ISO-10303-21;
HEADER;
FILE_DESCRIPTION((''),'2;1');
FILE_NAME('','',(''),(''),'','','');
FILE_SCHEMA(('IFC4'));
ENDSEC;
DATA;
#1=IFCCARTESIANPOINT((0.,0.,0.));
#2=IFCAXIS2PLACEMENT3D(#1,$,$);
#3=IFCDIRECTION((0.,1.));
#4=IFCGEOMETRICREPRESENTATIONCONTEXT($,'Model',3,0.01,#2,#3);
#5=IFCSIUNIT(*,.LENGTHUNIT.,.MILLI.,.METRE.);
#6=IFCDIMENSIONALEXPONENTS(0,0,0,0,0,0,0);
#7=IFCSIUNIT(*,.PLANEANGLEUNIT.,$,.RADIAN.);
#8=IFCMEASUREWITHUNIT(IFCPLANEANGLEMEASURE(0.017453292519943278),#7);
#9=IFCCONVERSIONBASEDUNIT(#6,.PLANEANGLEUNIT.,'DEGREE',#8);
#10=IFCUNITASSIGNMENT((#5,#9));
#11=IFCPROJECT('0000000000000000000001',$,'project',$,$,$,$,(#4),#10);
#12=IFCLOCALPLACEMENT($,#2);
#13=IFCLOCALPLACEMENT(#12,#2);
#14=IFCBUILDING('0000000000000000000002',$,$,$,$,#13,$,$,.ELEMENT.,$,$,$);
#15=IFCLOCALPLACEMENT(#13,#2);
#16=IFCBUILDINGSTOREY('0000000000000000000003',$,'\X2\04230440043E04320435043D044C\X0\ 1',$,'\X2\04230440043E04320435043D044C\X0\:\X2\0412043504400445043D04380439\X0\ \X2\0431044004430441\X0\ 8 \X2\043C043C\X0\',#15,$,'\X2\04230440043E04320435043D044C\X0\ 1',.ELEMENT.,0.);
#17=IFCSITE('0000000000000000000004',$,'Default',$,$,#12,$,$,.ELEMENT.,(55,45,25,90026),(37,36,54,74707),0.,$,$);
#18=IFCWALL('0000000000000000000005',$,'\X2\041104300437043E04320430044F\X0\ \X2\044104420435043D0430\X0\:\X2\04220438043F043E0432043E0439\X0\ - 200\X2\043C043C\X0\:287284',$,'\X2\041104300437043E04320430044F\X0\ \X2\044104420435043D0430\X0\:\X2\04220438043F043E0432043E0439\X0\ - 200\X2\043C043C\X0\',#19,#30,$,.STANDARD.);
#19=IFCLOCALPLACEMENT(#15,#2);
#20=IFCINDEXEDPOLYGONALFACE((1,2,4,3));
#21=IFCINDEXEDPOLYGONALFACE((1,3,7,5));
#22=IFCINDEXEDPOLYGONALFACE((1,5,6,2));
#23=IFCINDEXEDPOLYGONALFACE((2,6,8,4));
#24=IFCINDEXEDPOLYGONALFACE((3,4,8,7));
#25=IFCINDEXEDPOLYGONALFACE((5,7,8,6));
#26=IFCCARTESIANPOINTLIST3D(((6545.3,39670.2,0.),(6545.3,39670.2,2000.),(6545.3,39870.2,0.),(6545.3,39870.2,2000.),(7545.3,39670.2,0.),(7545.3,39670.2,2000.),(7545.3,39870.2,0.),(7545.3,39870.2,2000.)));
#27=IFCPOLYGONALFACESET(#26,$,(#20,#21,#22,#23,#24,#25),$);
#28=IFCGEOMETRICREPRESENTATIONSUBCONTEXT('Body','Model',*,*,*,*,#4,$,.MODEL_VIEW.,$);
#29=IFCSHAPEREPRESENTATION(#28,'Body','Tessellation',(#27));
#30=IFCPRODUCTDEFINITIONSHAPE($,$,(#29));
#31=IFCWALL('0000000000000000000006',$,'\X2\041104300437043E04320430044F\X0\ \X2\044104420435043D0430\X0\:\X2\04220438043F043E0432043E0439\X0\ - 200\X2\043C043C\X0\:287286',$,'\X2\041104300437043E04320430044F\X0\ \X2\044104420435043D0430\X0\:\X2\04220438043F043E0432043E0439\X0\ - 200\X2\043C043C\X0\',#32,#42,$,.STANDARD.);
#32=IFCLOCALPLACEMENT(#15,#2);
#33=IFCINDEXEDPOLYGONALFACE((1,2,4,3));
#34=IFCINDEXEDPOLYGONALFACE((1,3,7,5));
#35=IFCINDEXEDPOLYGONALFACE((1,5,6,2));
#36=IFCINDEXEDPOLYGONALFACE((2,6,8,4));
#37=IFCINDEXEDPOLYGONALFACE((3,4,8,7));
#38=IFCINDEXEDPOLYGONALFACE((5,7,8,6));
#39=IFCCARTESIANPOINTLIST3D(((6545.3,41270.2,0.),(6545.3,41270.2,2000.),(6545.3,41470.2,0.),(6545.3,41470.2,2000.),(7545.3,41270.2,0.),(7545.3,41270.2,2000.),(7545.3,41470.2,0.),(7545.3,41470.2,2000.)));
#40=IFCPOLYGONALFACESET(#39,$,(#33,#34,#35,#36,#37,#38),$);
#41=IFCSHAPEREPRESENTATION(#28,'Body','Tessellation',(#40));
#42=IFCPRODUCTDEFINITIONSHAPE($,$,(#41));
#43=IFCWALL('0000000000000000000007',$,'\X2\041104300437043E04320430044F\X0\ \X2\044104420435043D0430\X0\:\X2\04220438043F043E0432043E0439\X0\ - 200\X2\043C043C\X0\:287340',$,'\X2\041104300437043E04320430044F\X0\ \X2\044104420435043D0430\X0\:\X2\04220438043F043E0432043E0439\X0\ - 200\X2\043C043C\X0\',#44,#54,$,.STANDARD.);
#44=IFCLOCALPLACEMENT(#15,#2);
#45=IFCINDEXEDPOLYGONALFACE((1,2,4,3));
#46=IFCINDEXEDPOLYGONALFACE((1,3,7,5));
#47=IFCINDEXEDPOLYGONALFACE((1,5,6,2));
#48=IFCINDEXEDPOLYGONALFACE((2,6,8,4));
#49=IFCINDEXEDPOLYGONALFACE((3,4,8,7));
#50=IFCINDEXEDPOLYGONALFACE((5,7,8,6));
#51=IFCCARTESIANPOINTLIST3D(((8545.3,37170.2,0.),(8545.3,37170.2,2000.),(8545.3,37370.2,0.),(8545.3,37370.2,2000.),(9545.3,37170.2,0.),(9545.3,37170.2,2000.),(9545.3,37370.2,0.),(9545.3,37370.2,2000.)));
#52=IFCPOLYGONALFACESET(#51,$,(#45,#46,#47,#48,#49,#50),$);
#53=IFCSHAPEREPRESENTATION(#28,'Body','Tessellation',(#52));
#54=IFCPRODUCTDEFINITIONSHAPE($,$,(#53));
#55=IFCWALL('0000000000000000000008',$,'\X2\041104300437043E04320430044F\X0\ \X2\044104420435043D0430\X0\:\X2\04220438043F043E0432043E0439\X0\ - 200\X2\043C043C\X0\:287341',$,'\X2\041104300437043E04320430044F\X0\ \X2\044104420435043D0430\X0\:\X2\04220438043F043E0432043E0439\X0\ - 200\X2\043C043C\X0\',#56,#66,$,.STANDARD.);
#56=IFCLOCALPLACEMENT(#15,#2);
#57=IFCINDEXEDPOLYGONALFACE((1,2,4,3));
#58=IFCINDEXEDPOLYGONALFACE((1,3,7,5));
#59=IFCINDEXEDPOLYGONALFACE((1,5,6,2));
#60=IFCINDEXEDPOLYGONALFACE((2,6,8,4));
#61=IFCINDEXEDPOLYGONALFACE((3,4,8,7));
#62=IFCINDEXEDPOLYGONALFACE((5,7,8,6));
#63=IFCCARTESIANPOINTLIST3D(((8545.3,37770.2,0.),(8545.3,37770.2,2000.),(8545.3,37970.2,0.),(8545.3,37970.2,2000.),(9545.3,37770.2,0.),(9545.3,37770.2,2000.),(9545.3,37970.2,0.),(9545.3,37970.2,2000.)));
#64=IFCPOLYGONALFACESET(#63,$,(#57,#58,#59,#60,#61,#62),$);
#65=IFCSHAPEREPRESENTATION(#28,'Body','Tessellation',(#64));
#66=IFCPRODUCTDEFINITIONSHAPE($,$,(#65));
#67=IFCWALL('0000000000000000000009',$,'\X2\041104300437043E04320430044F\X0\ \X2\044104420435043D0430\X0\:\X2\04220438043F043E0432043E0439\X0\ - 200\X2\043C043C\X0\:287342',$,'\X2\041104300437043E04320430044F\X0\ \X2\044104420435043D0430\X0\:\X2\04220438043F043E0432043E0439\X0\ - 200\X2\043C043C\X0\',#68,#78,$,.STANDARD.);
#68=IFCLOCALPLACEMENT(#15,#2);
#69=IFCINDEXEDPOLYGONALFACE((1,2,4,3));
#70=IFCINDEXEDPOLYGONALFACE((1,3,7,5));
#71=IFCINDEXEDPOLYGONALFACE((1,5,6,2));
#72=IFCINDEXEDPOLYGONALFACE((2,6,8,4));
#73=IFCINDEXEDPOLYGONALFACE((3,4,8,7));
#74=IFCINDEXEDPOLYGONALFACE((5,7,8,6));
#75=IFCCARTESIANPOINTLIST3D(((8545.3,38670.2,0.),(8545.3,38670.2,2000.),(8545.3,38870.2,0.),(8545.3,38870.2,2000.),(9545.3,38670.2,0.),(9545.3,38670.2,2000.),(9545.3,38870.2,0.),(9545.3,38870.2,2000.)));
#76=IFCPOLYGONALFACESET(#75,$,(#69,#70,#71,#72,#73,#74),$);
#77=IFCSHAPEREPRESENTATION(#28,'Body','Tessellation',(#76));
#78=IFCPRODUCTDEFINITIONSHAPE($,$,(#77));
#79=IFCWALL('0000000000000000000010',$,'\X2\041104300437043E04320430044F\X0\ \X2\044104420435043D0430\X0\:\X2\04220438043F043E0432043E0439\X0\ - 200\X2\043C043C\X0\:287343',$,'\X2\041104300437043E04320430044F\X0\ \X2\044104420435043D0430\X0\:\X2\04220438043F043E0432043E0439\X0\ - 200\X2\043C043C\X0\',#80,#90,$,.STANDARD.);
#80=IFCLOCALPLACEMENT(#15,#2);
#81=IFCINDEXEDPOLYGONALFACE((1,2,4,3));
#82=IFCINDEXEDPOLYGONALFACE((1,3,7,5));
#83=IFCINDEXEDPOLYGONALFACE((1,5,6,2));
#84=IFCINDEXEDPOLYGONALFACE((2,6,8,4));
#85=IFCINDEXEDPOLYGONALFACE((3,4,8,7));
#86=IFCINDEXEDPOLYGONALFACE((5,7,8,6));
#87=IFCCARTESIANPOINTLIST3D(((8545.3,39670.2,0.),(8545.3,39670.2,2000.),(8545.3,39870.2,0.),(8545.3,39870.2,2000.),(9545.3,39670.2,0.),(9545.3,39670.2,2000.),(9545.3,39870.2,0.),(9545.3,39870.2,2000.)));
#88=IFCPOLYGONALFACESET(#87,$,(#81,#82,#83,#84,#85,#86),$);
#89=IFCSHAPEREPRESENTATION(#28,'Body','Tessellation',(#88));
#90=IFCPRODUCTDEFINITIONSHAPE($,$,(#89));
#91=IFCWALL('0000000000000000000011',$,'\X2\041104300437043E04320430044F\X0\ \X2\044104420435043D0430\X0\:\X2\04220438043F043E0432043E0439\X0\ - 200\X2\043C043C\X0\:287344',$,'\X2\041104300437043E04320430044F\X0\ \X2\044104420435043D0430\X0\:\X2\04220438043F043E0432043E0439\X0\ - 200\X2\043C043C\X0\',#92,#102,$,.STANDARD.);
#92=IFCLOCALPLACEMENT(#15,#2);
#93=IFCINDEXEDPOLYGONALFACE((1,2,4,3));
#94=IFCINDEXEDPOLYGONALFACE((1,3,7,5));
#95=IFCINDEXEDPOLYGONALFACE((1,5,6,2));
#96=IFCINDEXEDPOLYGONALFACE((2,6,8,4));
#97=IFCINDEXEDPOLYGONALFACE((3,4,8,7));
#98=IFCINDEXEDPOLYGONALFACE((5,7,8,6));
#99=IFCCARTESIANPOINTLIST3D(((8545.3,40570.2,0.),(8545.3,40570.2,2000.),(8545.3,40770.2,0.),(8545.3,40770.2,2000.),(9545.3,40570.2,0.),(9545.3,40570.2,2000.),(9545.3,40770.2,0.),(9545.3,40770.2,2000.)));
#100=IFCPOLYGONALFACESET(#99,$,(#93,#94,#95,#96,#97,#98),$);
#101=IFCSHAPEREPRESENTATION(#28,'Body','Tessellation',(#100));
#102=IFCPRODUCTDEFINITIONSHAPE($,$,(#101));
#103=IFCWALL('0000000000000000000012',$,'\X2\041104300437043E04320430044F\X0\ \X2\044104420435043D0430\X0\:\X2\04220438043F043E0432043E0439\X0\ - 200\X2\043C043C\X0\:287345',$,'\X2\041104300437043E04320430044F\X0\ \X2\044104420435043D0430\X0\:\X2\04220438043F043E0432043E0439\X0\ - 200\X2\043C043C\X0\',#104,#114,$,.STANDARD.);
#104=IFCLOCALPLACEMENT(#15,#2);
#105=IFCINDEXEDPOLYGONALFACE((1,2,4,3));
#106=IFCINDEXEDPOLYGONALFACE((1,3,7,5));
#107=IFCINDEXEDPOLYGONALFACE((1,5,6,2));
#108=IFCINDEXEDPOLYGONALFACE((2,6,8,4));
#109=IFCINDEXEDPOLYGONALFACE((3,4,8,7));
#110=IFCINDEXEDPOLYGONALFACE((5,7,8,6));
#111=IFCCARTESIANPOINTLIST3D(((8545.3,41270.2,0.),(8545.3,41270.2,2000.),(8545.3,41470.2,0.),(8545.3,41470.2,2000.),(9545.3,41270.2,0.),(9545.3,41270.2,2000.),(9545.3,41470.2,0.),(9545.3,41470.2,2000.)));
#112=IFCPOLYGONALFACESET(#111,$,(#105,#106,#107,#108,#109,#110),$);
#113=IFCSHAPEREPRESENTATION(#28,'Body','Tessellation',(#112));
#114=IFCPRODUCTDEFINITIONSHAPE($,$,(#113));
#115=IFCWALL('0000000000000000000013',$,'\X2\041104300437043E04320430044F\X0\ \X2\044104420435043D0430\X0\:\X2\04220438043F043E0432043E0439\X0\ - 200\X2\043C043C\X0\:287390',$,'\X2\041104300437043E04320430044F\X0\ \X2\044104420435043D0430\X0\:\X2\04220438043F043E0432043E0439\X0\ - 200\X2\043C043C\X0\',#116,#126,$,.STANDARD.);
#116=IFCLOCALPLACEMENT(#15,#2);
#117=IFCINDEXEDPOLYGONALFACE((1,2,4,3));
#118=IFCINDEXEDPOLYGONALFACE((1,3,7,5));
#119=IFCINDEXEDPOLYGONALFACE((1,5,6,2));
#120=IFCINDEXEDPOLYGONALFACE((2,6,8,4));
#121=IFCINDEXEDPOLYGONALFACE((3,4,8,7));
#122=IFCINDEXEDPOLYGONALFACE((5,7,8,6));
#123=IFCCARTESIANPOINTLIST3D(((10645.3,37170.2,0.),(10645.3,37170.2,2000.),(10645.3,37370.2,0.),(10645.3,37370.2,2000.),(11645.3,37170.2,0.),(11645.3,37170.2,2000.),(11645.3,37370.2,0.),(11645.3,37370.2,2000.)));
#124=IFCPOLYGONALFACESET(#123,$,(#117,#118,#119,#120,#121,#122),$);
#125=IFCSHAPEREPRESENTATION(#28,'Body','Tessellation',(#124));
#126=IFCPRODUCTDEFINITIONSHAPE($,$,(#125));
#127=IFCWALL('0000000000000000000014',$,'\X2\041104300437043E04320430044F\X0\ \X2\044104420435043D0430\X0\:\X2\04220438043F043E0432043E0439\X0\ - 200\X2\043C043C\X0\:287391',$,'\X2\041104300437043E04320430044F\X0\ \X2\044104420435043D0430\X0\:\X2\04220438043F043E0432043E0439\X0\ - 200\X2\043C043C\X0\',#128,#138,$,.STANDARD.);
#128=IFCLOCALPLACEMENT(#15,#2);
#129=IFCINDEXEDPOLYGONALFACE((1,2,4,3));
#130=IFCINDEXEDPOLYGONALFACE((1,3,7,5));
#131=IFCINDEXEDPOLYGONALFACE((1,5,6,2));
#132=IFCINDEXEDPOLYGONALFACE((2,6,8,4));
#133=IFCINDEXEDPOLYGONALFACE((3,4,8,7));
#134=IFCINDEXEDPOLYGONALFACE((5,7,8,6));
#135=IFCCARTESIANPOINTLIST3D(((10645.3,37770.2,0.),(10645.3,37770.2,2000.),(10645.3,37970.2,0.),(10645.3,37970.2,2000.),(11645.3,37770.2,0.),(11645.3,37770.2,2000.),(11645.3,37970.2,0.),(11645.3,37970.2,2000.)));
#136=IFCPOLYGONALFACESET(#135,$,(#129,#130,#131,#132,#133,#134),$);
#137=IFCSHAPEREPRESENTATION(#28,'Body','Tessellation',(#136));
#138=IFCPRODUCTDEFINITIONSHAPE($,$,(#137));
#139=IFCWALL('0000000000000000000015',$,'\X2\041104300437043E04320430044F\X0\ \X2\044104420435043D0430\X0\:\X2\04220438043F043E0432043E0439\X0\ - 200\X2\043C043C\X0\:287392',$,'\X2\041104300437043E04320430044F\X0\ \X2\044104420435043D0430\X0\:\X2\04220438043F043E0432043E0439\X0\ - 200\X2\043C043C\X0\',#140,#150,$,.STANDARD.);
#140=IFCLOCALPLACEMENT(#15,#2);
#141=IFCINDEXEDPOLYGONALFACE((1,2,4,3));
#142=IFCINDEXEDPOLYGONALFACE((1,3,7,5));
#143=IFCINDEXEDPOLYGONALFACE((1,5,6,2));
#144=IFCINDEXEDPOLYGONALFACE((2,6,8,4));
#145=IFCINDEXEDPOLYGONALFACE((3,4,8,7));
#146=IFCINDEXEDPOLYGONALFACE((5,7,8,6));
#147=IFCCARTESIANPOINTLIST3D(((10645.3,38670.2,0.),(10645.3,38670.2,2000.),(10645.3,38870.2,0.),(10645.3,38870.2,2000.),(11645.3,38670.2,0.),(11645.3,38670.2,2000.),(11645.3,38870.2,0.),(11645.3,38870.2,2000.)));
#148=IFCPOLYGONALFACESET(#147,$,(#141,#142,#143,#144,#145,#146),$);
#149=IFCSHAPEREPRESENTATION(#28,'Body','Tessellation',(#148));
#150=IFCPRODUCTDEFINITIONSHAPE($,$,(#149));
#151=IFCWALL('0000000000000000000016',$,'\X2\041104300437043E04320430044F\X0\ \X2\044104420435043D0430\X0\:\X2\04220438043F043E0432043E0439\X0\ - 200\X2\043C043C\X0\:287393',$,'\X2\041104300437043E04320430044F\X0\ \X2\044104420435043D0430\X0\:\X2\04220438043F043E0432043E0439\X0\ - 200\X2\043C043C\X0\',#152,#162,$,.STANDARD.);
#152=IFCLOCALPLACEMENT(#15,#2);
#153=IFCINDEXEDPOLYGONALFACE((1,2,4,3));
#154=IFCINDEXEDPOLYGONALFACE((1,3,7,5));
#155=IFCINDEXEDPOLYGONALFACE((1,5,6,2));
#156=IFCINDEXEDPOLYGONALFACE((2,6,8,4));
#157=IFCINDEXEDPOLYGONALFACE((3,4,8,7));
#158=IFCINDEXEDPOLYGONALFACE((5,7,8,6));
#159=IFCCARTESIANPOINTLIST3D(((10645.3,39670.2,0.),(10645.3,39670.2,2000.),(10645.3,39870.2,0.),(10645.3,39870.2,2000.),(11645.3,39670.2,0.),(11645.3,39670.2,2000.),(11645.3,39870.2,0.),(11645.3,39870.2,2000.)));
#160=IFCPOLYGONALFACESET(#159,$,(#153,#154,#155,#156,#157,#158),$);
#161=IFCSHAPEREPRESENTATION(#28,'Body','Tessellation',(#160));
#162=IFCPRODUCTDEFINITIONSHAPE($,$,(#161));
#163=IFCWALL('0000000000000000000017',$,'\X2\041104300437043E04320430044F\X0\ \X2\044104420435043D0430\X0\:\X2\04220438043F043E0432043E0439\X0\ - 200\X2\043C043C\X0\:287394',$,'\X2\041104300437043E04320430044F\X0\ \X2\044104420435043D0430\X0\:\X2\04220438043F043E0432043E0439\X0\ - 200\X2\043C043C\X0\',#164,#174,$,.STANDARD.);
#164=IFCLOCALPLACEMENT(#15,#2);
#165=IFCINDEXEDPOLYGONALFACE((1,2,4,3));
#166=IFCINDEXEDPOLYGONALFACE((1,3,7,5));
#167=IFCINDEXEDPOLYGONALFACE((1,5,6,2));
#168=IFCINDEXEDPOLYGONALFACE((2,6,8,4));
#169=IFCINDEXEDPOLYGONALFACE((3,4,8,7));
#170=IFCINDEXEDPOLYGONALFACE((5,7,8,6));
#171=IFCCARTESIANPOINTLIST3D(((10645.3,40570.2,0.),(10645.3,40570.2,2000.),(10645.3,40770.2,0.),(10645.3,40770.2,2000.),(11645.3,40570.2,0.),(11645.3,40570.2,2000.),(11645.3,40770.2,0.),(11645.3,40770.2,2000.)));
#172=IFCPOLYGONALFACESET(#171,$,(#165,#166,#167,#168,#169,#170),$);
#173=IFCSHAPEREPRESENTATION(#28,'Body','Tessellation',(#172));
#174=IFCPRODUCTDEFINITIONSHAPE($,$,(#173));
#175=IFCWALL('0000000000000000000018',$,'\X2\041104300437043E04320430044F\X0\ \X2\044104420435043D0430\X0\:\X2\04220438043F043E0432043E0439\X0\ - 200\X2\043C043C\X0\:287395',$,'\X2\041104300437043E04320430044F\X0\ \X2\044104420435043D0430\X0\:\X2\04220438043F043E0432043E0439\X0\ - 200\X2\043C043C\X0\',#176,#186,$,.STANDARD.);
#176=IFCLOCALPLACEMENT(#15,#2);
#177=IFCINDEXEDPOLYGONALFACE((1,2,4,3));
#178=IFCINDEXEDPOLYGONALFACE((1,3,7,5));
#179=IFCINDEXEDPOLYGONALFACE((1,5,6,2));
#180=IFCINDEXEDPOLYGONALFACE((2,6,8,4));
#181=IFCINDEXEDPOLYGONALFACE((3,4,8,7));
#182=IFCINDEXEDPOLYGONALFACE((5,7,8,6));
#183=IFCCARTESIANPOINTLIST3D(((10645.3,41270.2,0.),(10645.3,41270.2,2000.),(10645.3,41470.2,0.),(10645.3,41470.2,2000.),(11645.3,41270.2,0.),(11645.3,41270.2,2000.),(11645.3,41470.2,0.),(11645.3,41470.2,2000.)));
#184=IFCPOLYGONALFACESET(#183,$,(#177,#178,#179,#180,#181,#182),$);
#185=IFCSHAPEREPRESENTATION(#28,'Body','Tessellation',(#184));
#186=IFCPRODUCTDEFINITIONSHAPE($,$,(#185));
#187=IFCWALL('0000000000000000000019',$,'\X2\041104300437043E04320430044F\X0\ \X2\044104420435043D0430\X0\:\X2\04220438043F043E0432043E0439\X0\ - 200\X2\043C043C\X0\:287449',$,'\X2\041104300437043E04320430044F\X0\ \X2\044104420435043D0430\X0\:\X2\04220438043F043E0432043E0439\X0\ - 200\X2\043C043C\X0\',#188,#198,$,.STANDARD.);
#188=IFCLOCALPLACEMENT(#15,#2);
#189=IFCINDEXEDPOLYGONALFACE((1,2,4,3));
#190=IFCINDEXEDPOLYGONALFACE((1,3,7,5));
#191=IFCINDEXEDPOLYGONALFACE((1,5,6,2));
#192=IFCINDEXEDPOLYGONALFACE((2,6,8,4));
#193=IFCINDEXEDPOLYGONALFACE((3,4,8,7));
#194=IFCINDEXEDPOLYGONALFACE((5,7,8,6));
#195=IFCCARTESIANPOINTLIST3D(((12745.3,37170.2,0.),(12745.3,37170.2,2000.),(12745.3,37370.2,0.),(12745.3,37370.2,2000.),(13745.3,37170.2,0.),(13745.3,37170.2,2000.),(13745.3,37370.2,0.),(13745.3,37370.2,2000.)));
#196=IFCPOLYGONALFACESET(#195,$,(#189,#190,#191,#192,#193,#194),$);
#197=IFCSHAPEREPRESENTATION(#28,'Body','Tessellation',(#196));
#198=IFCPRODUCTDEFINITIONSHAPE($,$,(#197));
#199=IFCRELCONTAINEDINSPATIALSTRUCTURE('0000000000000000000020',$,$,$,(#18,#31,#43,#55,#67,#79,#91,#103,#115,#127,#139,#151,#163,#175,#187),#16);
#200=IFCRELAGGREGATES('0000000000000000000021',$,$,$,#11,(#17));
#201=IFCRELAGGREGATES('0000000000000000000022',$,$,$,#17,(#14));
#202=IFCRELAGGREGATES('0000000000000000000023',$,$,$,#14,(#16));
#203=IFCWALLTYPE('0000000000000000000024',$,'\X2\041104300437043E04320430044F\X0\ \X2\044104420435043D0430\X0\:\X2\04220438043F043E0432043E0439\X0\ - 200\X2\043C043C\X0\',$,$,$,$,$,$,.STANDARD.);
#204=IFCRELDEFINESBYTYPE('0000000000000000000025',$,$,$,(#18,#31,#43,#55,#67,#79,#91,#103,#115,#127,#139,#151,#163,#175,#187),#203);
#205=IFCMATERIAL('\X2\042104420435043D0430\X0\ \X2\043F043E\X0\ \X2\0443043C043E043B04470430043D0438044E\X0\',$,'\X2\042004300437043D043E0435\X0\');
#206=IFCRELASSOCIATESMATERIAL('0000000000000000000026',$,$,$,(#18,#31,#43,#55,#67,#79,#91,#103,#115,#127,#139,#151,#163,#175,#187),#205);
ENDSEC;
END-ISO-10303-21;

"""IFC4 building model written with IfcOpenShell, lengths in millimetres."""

from ifc_helpers import new_model, entity, si_unit, converted_unit, direction, frame, origin, place, context, subcontext, project, spatial, indexed_curve, outline, extrude, material, type_object, element, save


model = new_model("IFC4")

# Units and contexts
model_context = context("Model", 3, precision=0.01, world=origin(), true_north=direction((0.0, 1.0)))
body_context = subcontext(model_context, "Body", "Model", "MODEL_VIEW")
ifc_project = project(units=[si_unit("LENGTHUNIT", "METRE", prefix="MILLI"), converted_unit("PLANEANGLEUNIT", "DEGREE", entity("IfcPlaneAngleMeasure", 0.017453292519943278), si_unit("PLANEANGLEUNIT", "RADIAN"), dimensions=[0, 0, 0, 0, 0, 0, 0])], contexts=[model_context])

# Site, building, storey
site_placement = place(None, origin())
site = spatial("IfcSite", under=ifc_project, at=site_placement, Name="Default", CompositionType="ELEMENT", RefLatitude=(55, 45, 25, 90026), RefLongitude=(37, 36, 54, 74707), RefElevation=0.0)
building_placement = place(site_placement, origin())
building = spatial("IfcBuilding", under=site, at=building_placement, CompositionType="ELEMENT")
storey_placement = place(building_placement, origin())
storey = spatial("IfcBuildingStorey", under=building, at=storey_placement, Name="Уровень 1", ObjectType="Уровень:Верхний брус 8 мм", LongName="Уровень 1", CompositionType="ELEMENT", Elevation=0.0)

# Walls
ifc_material = material(Name="Стена по умолчанию", Category="Разное")
wall_type = type_object("IfcWallType", Name="Базовая стена:Типовой - 200мм", PredefinedType="STANDARD")
wall_1_placement = place(storey_placement, frame((6545.3, 39770.2, 0.0)))
element("IfcWall", 1, at=wall_1_placement, inside=storey, type_object=wall_type, material=ifc_material, Name="Базовая стена:Типовой - 200мм:287284", ObjectType="Базовая стена:Типовой - 200мм", PredefinedType="STANDARD", context=body_context, shape_type="SweptSolid", body=[
    extrude(outline(indexed_curve([(1000.0, 100.0), (0.0, 100.0), (0.0, -100.0), (1000.0, -100.0), (1000.0, 100.0)], self_intersect=False)), origin(), (0.0, 0.0, 1.0), 2000.0),
])
wall_2_placement = place(storey_placement, frame((6545.3, 41370.2, 0.0)))
element("IfcWall", 2, at=wall_2_placement, inside=storey, type_object=wall_type, material=ifc_material, Name="Базовая стена:Типовой - 200мм:287286", ObjectType="Базовая стена:Типовой - 200мм", PredefinedType="STANDARD", context=body_context, shape_type="SweptSolid", body=[
    extrude(outline(indexed_curve([(1000.0, 100.0), (0.0, 100.0), (0.0, -100.0), (1000.0, -100.0), (1000.0, 100.0)], self_intersect=False)), origin(), (0.0, 0.0, 1.0), 2000.0),
])
wall_3_placement = place(storey_placement, frame((8545.3, 37270.2, 0.0)))
element("IfcWall", 3, at=wall_3_placement, inside=storey, type_object=wall_type, material=ifc_material, Name="Базовая стена:Типовой - 200мм:287340", ObjectType="Базовая стена:Типовой - 200мм", PredefinedType="STANDARD", context=body_context, shape_type="SweptSolid", body=[
    extrude(outline(indexed_curve([(1000.0, 100.0), (0.0, 100.0), (0.0, -100.0), (1000.0, -100.0), (1000.0, 100.0)], self_intersect=False)), origin(), (0.0, 0.0, 1.0), 2000.0),
])
for number, where, name in (
    (4, (8545.3, 37870.2, 0.0), "Базовая стена:Типовой - 200мм:287341"),
    (5, (8545.3, 38770.2, 0.0), "Базовая стена:Типовой - 200мм:287342"),
):
    element("IfcWall", number, at=place(storey_placement, frame(where)), inside=storey, type_object=wall_type, material=ifc_material, Name=name, ObjectType="Базовая стена:Типовой - 200мм", PredefinedType="STANDARD", context=body_context, shape_type="SweptSolid", body=[
        extrude(outline(indexed_curve([(1000.0, 100.0), (0.0, 100.0), (0.0, -100.0), (1000.0, -100.0), (1000.0, 100.0)], self_intersect=False)), origin(), (0.0, 0.0, 1.0), 2000.0),
    ])
wall_4_placement = place(storey_placement, frame((8545.3, 39770.2, 0.0)))
element("IfcWall", 6, at=wall_4_placement, inside=storey, type_object=wall_type, material=ifc_material, Name="Базовая стена:Типовой - 200мм:287343", ObjectType="Базовая стена:Типовой - 200мм", PredefinedType="STANDARD", context=body_context, shape_type="SweptSolid", body=[
    extrude(outline(indexed_curve([(1000.0, 100.0), (0.0, 100.0), (0.0, -100.0), (1000.0, -100.0), (1000.0, 100.0)], self_intersect=False)), origin(), (0.0, 0.0, 1.0), 2000.0),
])
for number, where, name in (
    (7, (8545.3, 40670.2, 0.0), "Базовая стена:Типовой - 200мм:287344"),
    (8, (8545.3, 41370.2, 0.0), "Базовая стена:Типовой - 200мм:287345"),
):
    element("IfcWall", number, at=place(storey_placement, frame(where)), inside=storey, type_object=wall_type, material=ifc_material, Name=name, ObjectType="Базовая стена:Типовой - 200мм", PredefinedType="STANDARD", context=body_context, shape_type="SweptSolid", body=[
        extrude(outline(indexed_curve([(1000.0, 100.0), (0.0, 100.0), (0.0, -100.0), (1000.0, -100.0), (1000.0, 100.0)], self_intersect=False)), origin(), (0.0, 0.0, 1.0), 2000.0),
    ])
wall_5_placement = place(storey_placement, frame((10645.3, 37270.2, 0.0)))
element("IfcWall", 9, at=wall_5_placement, inside=storey, type_object=wall_type, material=ifc_material, Name="Базовая стена:Типовой - 200мм:287390", ObjectType="Базовая стена:Типовой - 200мм", PredefinedType="STANDARD", context=body_context, shape_type="SweptSolid", body=[
    extrude(outline(indexed_curve([(1000.0, 100.0), (0.0, 100.0), (0.0, -100.0), (1000.0, -100.0), (1000.0, 100.0)], self_intersect=False)), origin(), (0.0, 0.0, 1.0), 2000.0),
])
for number, where, name in (
    (10, (10645.3, 37870.2, 0.0), "Базовая стена:Типовой - 200мм:287391"),
    (11, (10645.3, 38770.2, 0.0), "Базовая стена:Типовой - 200мм:287392"),
):
    element("IfcWall", number, at=place(storey_placement, frame(where)), inside=storey, type_object=wall_type, material=ifc_material, Name=name, ObjectType="Базовая стена:Типовой - 200мм", PredefinedType="STANDARD", context=body_context, shape_type="SweptSolid", body=[
        extrude(outline(indexed_curve([(1000.0, 100.0), (0.0, 100.0), (0.0, -100.0), (1000.0, -100.0), (1000.0, 100.0)], self_intersect=False)), origin(), (0.0, 0.0, 1.0), 2000.0),
    ])
wall_6_placement = place(storey_placement, frame((10645.3, 39770.2, 0.0)))
element("IfcWall", 12, at=wall_6_placement, inside=storey, type_object=wall_type, material=ifc_material, Name="Базовая стена:Типовой - 200мм:287393", ObjectType="Базовая стена:Типовой - 200мм", PredefinedType="STANDARD", context=body_context, shape_type="SweptSolid", body=[
    extrude(outline(indexed_curve([(1000.0, 100.0), (0.0, 100.0), (0.0, -100.0), (1000.0, -100.0), (1000.0, 100.0)], self_intersect=False)), origin(), (0.0, 0.0, 1.0), 2000.0),
])
for number, where, name in (
    (13, (10645.3, 40670.2, 0.0), "Базовая стена:Типовой - 200мм:287394"),
    (14, (10645.3, 41370.2, 0.0), "Базовая стена:Типовой - 200мм:287395"),
):
    element("IfcWall", number, at=place(storey_placement, frame(where)), inside=storey, type_object=wall_type, material=ifc_material, Name=name, ObjectType="Базовая стена:Типовой - 200мм", PredefinedType="STANDARD", context=body_context, shape_type="SweptSolid", body=[
        extrude(outline(indexed_curve([(1000.0, 100.0), (0.0, 100.0), (0.0, -100.0), (1000.0, -100.0), (1000.0, 100.0)], self_intersect=False)), origin(), (0.0, 0.0, 1.0), 2000.0),
    ])
wall_7_placement = place(storey_placement, frame((12745.3, 37270.2, 0.0)))
element("IfcWall", 15, at=wall_7_placement, inside=storey, type_object=wall_type, material=ifc_material, Name="Базовая стена:Типовой - 200мм:287449", ObjectType="Базовая стена:Типовой - 200мм", PredefinedType="STANDARD", context=body_context, shape_type="SweptSolid", body=[
    extrude(outline(indexed_curve([(1000.0, 100.0), (0.0, 100.0), (0.0, -100.0), (1000.0, -100.0), (1000.0, 100.0)], self_intersect=False)), origin(), (0.0, 0.0, 1.0), 2000.0),
])

save(model, "model.ifc")
